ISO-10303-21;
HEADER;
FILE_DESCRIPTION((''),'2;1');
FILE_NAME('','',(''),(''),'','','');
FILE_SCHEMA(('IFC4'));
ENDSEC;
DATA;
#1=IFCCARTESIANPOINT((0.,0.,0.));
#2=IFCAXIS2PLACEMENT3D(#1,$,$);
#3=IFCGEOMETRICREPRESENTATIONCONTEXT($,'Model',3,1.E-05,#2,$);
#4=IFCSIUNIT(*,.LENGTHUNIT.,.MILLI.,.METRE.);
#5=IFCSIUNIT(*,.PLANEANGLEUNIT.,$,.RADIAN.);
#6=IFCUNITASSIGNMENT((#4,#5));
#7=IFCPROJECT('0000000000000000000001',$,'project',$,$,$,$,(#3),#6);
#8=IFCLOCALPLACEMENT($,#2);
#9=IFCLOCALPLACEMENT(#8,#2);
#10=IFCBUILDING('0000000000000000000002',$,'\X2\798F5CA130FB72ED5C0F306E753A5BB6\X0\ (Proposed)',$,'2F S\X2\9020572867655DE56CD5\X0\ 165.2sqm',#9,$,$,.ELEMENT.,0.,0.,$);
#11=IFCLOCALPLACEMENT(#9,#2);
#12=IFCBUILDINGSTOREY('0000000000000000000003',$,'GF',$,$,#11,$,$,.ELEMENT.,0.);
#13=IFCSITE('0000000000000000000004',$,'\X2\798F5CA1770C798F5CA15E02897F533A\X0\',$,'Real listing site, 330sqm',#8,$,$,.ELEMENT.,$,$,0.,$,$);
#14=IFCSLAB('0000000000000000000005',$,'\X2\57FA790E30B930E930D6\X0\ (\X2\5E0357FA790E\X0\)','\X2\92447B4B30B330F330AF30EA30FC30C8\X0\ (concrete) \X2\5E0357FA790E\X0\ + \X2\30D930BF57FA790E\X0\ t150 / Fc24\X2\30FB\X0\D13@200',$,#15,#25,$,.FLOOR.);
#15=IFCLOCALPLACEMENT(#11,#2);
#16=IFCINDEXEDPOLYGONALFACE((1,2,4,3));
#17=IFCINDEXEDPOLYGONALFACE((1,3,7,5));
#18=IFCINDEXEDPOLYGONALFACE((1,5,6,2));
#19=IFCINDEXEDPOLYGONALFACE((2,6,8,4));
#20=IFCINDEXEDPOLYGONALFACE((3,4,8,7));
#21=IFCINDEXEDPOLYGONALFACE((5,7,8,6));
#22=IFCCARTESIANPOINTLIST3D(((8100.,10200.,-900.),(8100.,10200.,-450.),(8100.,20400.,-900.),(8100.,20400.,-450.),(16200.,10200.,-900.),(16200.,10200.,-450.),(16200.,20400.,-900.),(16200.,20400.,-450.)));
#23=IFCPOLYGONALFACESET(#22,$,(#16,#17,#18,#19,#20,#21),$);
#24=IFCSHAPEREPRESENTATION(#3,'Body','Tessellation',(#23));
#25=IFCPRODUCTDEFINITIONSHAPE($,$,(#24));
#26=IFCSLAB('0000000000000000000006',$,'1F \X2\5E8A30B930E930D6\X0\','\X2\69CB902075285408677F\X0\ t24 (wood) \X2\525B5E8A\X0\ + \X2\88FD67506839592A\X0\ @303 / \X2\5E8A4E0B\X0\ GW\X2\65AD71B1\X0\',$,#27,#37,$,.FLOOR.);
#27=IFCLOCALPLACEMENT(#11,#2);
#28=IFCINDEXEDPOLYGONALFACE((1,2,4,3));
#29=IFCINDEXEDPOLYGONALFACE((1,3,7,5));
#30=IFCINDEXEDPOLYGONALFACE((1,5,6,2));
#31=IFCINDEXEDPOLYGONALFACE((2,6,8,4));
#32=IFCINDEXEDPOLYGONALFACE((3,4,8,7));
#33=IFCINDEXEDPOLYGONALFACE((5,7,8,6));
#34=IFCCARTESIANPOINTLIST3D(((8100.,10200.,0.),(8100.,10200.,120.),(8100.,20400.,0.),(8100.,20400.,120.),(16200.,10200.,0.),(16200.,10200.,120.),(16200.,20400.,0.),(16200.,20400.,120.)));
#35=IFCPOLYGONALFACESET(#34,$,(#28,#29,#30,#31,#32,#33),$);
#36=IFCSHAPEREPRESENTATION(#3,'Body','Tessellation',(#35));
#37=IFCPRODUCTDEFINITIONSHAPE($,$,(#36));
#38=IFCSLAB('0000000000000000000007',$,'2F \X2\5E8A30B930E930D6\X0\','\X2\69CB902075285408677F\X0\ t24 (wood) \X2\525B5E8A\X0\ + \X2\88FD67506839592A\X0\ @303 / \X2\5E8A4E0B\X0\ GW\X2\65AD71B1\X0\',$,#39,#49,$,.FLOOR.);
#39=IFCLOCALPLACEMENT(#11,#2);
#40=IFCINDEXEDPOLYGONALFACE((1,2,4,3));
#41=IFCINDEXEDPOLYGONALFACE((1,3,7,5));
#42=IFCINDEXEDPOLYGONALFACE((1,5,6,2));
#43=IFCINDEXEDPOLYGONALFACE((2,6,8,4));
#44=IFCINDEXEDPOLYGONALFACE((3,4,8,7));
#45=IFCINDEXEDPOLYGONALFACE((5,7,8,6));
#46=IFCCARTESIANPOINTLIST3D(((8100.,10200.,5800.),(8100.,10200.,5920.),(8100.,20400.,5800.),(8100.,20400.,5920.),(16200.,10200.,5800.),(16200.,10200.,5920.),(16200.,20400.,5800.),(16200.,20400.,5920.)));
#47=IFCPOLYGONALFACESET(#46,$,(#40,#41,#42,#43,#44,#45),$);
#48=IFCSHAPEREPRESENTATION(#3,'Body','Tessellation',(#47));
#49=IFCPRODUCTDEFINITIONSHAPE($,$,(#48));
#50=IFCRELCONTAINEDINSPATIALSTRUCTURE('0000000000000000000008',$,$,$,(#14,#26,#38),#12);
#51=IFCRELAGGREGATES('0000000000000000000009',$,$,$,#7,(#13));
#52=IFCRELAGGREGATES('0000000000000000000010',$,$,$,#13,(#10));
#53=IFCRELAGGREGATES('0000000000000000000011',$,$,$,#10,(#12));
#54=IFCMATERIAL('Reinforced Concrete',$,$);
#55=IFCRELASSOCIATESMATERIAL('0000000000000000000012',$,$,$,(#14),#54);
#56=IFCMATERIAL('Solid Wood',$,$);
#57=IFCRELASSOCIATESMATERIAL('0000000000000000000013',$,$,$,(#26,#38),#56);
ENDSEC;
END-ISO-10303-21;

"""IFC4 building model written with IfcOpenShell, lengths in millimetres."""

from ifc_helpers import new_model, si_unit, frame, frame_2d, origin, place, context, project, spatial, rectangle, extrude, material, element, save


model = new_model("IFC4")

# Units and contexts
model_context = context("Model", 3, precision=1e-05, world=origin())
ifc_project = project(units=[si_unit("LENGTHUNIT", "METRE", prefix="MILLI"), si_unit("PLANEANGLEUNIT", "RADIAN")], contexts=[model_context])

# Site, building, storey
site_placement = place(None, origin())
site = spatial("IfcSite", under=ifc_project, at=site_placement, Name="福岡県福岡市西区", ObjectType="Real listing site, 330sqm", CompositionType="ELEMENT", RefElevation=0.0)
building_placement = place(site_placement, origin())
building = spatial("IfcBuilding", under=site, at=building_placement, Name="福岡・狭小の町家 (Proposed)", ObjectType="2F S造在来工法 165.2sqm", CompositionType="ELEMENT", ElevationOfRefHeight=0.0, ElevationOfTerrain=0.0)
storey_placement = place(building_placement, origin())
storey = spatial("IfcBuildingStorey", under=building, at=storey_placement, Name="GF", CompositionType="ELEMENT", Elevation=0.0)

# Shared definitions
ifc_material_1 = material(Name="Solid Wood")

# Slabs
ifc_material_2 = material(Name="Reinforced Concrete")
slab_1_placement = place(storey_placement, frame((4050.0, 5100.0, -450.0)))
element("IfcSlab", 1, at=slab_1_placement, inside=storey, material=ifc_material_2, Name="基礎スラブ (布基礎)", Description="鉄筋コンクリート (concrete) 布基礎 + ベタ基礎 t150 / Fc24・D13@200", PredefinedType="FLOOR", context=model_context, shape_type="SweptSolid", body=[
    extrude(rectangle(XDim=8100.0, YDim=10200.0, at=frame_2d((4050.0, 5100.0))), frame((4050.0, 5100.0, -450.0)), (0.0, 0.0, 1.0), 450.0),
])
slab_2_placement = place(storey_placement, frame((4050.0, 5100.0, 0.0)))
element("IfcSlab", 2, at=slab_2_placement, inside=storey, material=ifc_material_1, Name="1F 床スラブ", Description="構造用合板 t24 (wood) 剛床 + 製材根太 @303 / 床下 GW断熱", PredefinedType="FLOOR", context=model_context, shape_type="SweptSolid", body=[
    extrude(rectangle(XDim=8100.0, YDim=10200.0, at=frame_2d((4050.0, 5100.0))), frame((4050.0, 5100.0, 0.0)), (0.0, 0.0, 1.0), 120.0),
])
slab_3_placement = place(storey_placement, frame((4050.0, 5100.0, 2900.0)))
element("IfcSlab", 3, at=slab_3_placement, inside=storey, material=ifc_material_1, Name="2F 床スラブ", Description="構造用合板 t24 (wood) 剛床 + 製材根太 @303 / 床下 GW断熱", PredefinedType="FLOOR", context=model_context, shape_type="SweptSolid", body=[
    extrude(rectangle(XDim=8100.0, YDim=10200.0, at=frame_2d((4050.0, 5100.0))), frame((4050.0, 5100.0, 2900.0)), (0.0, 0.0, 1.0), 120.0),
])

save(model, "model.ifc")
